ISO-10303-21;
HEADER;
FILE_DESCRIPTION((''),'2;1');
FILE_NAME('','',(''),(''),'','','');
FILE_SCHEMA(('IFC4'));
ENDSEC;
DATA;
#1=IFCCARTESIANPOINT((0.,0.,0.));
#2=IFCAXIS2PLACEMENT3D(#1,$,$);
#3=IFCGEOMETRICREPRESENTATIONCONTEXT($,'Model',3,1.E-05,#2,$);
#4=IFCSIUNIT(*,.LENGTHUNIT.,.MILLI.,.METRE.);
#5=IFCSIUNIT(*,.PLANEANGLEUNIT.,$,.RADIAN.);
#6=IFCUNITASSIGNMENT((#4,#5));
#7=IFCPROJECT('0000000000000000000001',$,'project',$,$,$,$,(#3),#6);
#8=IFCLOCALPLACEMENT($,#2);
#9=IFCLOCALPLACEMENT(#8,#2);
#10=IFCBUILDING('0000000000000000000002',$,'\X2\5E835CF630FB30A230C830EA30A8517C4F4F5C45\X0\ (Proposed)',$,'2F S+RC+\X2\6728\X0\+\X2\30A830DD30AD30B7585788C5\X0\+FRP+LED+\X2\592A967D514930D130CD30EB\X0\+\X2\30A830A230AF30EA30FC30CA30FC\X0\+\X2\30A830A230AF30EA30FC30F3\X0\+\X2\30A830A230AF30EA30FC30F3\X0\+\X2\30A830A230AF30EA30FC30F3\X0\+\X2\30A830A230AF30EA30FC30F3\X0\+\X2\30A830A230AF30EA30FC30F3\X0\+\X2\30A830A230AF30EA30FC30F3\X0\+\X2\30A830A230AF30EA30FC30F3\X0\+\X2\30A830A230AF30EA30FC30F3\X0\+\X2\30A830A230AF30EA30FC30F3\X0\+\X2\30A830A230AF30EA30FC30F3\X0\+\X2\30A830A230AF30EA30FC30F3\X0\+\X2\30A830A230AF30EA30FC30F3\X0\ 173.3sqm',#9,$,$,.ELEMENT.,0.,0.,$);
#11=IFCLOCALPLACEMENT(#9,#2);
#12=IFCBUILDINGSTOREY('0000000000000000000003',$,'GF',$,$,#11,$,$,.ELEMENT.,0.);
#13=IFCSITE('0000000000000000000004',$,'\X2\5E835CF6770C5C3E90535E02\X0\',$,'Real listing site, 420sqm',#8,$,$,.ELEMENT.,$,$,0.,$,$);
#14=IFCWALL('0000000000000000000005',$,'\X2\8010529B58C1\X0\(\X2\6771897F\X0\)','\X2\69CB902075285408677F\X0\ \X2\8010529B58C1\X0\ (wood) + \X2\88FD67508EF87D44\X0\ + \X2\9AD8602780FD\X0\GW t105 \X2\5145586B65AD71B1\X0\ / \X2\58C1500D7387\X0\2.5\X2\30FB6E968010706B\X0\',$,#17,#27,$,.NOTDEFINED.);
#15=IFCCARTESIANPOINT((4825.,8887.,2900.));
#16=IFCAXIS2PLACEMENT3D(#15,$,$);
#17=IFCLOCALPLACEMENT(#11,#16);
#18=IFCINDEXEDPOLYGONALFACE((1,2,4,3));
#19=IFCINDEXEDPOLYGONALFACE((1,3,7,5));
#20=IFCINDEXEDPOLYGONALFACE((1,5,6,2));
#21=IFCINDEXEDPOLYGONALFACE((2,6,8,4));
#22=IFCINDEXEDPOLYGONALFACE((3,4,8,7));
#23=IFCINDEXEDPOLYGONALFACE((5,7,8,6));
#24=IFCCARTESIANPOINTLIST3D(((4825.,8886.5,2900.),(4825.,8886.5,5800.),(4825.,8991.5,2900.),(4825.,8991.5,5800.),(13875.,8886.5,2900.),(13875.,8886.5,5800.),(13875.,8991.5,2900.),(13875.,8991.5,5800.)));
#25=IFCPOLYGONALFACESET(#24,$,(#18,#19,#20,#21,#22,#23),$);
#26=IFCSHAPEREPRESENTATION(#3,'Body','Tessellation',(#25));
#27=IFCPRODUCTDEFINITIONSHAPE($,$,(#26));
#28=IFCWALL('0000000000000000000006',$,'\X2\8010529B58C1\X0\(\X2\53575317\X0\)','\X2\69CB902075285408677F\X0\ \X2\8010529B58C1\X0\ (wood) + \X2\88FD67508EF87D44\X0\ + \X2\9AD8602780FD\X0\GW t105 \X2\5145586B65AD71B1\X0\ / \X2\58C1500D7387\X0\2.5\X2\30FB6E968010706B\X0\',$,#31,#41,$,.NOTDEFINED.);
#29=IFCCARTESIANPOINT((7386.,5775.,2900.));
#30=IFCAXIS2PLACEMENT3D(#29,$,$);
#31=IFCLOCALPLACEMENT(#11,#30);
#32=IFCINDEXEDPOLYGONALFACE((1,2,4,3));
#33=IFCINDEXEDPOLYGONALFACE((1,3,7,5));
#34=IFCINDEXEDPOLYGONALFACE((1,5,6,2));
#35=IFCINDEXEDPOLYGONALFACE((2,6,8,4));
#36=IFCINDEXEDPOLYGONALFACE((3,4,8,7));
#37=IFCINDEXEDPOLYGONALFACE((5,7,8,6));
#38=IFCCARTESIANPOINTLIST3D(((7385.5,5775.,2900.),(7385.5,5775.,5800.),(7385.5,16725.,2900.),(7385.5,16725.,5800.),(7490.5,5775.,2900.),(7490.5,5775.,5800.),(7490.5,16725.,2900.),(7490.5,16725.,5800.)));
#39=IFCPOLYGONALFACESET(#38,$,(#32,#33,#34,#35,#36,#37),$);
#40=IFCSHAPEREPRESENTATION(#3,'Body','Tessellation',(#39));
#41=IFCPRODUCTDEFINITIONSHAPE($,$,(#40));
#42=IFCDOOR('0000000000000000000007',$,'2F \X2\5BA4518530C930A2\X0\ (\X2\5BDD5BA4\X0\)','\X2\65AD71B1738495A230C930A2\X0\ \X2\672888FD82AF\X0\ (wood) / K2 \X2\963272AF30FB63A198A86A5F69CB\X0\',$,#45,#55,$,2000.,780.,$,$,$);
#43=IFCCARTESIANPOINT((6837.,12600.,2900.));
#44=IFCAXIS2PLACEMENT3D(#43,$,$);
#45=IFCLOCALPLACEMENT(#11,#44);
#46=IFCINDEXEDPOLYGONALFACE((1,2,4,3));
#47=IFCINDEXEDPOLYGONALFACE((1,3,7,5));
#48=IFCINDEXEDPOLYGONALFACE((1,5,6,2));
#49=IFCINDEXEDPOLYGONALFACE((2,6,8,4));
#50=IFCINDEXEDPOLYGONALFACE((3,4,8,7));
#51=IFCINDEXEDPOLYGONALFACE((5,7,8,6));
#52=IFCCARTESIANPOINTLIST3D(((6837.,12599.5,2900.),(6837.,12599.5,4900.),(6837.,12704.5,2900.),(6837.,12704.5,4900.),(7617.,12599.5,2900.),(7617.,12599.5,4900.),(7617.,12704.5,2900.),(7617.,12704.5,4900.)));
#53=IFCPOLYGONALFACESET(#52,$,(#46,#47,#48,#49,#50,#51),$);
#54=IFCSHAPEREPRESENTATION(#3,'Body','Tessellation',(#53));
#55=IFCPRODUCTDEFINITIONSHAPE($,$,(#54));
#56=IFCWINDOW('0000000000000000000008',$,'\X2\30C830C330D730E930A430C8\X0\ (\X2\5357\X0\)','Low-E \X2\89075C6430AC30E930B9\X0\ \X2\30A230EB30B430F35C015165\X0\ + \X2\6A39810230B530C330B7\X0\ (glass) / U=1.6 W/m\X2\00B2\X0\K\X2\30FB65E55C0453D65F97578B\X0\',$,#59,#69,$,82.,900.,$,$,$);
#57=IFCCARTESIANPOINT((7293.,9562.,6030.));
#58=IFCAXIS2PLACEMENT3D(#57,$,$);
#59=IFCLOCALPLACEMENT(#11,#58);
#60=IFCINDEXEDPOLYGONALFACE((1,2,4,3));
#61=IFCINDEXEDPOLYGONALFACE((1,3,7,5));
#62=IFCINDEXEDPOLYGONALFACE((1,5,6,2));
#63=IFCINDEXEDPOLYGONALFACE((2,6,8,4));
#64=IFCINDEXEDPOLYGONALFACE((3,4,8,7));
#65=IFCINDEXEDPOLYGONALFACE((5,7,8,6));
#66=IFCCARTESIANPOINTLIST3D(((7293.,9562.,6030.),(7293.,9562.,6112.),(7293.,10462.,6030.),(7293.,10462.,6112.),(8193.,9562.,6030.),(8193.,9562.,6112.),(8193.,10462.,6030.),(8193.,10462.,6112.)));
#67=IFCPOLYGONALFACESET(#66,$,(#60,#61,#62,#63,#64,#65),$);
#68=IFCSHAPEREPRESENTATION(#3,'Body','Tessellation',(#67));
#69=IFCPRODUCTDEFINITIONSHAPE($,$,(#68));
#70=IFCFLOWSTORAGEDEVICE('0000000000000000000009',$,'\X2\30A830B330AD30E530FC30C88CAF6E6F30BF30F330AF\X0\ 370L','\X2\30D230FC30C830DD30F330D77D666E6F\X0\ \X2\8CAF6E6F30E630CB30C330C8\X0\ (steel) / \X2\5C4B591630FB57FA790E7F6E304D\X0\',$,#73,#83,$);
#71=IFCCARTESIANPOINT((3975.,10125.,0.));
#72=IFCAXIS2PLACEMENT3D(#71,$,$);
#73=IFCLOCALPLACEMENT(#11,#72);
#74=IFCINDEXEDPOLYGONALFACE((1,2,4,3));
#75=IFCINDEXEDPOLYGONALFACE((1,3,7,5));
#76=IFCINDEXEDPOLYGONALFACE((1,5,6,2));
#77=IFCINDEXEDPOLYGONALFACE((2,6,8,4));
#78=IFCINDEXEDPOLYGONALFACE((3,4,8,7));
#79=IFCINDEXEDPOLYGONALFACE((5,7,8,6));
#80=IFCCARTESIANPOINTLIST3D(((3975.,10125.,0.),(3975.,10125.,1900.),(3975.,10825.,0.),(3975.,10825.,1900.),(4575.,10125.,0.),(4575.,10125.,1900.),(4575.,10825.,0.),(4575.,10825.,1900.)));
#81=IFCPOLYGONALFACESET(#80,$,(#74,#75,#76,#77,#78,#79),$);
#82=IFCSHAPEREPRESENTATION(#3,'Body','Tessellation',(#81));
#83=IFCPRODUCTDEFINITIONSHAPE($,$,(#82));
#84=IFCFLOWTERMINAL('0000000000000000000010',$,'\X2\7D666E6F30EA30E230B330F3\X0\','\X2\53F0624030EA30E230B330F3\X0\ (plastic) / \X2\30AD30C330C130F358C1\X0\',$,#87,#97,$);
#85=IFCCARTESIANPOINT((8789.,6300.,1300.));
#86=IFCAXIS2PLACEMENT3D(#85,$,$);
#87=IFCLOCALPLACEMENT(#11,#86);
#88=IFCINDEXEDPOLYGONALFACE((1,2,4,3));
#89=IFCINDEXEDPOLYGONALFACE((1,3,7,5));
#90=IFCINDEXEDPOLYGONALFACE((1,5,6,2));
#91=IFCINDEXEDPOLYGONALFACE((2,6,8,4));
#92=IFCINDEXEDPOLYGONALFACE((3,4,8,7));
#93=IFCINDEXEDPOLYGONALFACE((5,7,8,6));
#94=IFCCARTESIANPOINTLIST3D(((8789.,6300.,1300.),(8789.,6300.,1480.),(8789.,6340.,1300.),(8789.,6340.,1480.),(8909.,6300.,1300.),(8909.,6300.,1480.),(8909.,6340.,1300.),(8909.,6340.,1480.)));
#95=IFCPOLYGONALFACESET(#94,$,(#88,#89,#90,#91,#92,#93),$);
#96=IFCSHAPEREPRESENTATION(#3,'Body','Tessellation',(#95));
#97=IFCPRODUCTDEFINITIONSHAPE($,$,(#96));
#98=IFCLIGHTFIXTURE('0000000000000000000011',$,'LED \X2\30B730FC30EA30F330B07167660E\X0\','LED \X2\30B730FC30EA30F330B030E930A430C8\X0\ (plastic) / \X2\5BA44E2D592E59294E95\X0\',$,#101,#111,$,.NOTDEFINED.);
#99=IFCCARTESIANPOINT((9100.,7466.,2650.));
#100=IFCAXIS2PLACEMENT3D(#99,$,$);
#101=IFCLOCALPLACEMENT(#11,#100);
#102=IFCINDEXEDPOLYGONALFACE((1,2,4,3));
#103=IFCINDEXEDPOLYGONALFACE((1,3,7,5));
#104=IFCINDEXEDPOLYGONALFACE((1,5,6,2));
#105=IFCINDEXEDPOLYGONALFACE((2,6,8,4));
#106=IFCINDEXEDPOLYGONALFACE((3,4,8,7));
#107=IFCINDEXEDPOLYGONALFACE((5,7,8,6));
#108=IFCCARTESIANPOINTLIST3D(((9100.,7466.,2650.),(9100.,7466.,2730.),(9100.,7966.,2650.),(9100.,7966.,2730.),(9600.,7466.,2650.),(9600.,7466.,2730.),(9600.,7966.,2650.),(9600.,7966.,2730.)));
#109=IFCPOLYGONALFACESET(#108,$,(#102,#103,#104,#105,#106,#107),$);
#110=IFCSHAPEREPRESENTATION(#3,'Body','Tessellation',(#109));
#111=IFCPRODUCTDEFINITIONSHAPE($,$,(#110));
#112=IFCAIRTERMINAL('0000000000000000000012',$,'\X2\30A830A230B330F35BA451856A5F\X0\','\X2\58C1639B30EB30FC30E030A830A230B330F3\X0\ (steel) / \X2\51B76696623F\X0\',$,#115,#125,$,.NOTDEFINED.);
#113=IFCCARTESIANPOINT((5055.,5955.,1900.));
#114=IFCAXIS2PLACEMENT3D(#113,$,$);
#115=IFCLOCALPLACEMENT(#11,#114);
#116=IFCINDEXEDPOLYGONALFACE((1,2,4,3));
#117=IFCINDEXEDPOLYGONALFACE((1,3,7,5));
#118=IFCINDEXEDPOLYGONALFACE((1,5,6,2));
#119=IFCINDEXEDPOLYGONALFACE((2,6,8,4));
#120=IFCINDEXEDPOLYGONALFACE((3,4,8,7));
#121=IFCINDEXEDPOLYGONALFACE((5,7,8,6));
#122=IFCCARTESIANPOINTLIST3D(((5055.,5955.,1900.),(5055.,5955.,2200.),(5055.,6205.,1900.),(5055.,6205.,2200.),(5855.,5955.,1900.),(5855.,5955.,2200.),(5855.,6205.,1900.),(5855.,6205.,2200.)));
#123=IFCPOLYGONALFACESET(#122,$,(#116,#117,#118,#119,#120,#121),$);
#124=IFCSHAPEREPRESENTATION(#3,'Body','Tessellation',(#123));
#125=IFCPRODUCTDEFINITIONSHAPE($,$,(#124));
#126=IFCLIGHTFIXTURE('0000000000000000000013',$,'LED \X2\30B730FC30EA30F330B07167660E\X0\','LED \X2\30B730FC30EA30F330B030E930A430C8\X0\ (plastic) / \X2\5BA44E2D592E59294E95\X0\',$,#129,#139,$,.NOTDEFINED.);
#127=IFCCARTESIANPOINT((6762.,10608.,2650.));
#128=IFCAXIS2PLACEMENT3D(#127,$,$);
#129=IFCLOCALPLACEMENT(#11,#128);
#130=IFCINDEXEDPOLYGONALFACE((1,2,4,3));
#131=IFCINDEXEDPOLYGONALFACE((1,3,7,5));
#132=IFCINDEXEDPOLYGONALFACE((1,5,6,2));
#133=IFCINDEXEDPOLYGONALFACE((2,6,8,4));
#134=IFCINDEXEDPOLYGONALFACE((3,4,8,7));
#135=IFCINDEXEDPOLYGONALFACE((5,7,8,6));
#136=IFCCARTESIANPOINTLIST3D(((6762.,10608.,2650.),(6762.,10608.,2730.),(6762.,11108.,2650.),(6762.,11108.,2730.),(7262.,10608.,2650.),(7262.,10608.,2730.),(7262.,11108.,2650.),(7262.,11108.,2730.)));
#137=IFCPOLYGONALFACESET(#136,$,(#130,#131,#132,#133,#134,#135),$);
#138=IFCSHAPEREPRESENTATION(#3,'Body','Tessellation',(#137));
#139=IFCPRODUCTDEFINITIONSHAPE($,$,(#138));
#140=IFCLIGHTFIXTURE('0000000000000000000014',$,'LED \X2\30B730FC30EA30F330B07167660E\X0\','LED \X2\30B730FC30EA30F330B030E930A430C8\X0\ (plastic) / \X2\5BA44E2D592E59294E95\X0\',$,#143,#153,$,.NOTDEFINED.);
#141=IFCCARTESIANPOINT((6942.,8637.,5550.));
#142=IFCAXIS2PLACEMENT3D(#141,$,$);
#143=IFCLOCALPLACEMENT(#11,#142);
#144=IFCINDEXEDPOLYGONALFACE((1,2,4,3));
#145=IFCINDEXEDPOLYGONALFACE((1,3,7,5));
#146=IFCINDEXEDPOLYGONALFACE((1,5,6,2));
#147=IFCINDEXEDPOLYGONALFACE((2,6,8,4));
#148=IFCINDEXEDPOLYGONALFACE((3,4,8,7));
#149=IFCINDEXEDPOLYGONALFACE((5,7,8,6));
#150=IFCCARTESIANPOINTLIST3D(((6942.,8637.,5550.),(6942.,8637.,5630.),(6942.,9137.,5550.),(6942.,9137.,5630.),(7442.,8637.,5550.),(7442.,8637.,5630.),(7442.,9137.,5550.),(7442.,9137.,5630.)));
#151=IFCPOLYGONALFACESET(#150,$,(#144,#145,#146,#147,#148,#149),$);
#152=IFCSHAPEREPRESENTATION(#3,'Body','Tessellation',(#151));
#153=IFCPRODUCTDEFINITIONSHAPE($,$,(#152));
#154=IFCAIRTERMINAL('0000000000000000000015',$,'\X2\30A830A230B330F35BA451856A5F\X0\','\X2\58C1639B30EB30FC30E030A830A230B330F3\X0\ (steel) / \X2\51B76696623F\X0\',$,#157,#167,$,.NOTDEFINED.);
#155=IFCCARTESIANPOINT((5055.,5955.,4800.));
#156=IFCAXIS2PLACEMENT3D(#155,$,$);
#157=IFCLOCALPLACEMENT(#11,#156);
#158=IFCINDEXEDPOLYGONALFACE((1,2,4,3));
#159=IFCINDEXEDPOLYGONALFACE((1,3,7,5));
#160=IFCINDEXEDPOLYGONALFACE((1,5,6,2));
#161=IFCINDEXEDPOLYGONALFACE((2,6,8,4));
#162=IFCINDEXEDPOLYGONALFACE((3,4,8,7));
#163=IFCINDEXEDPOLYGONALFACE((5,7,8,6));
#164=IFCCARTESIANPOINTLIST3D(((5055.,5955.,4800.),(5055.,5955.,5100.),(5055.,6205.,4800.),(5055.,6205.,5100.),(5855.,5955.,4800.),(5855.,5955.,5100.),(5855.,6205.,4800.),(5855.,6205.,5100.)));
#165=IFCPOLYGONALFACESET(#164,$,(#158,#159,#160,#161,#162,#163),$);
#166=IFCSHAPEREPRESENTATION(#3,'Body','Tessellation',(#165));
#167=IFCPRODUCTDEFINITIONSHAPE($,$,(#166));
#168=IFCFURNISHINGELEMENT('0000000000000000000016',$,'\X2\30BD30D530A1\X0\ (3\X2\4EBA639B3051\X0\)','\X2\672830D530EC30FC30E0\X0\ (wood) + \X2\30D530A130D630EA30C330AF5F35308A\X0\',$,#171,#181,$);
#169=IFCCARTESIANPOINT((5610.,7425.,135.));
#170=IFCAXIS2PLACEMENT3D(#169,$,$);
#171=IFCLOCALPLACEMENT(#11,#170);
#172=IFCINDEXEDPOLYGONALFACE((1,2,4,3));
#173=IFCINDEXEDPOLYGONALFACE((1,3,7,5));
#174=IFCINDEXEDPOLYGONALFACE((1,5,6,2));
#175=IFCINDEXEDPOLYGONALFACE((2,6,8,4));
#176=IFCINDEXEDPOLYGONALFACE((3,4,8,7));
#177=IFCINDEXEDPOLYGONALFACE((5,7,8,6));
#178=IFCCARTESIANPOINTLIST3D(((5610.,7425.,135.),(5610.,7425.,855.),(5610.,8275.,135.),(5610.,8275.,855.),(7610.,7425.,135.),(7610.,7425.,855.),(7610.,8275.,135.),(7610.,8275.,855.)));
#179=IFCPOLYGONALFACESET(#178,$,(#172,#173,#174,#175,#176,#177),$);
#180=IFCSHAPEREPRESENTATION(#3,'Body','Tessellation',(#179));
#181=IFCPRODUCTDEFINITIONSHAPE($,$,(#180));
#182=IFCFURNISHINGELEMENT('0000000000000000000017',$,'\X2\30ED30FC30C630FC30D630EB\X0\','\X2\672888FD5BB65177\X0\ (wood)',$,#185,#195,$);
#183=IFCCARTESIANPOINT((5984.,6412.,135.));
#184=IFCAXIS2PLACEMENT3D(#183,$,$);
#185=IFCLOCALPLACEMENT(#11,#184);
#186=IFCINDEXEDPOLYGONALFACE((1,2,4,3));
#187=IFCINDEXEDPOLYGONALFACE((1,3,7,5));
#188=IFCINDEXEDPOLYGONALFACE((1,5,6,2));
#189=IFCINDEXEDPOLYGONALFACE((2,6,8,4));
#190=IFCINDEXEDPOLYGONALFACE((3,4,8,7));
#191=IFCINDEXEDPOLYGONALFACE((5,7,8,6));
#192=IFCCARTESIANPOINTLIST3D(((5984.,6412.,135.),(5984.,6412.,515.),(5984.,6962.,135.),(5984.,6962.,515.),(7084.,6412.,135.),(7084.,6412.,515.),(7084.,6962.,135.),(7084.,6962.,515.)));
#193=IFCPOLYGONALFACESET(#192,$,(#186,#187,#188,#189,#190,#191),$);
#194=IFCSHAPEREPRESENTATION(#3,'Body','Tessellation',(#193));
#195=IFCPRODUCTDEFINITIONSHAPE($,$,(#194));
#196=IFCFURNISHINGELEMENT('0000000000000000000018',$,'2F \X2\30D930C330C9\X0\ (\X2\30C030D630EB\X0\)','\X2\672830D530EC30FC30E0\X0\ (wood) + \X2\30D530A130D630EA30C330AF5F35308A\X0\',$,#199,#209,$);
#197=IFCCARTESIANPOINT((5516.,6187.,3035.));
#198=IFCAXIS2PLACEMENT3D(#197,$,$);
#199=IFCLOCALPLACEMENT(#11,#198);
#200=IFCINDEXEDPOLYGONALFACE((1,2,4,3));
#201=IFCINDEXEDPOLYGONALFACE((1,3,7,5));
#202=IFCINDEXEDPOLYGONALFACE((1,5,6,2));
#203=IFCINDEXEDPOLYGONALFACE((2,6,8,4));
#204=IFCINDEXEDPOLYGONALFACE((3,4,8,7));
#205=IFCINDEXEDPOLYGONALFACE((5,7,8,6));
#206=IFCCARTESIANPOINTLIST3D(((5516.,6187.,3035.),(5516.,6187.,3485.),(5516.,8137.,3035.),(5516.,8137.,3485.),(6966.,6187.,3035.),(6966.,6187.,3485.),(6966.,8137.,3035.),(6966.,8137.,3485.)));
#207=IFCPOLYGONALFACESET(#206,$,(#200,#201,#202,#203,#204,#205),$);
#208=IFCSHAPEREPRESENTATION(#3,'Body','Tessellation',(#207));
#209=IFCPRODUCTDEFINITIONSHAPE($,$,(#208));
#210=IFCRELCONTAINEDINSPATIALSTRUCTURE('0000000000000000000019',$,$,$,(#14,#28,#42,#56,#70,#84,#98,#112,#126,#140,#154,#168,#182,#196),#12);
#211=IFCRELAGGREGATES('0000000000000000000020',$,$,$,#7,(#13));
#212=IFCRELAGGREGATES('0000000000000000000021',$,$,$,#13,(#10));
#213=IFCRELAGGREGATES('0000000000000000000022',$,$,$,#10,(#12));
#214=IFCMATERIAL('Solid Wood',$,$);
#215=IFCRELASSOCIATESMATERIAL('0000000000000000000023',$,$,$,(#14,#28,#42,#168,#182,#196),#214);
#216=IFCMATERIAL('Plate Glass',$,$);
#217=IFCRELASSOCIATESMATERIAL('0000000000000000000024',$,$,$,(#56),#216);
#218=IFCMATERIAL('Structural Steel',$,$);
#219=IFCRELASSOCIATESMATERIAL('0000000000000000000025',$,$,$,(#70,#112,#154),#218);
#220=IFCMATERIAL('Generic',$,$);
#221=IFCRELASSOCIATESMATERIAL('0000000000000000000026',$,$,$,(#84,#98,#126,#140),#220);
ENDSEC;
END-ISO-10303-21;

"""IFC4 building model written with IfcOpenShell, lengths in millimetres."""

from ifc_helpers import new_model, si_unit, frame, frame_2d, origin, place, context, project, spatial, rectangle, extrude, material, element, fill, save


model = new_model("IFC4")

# Units and contexts
model_context = context("Model", 3, precision=1e-05, world=origin())
ifc_project = project(units=[si_unit("LENGTHUNIT", "METRE", prefix="MILLI"), si_unit("PLANEANGLEUNIT", "RADIAN")], contexts=[model_context])

# Site, building, storey
site_placement = place(None, origin())
site = spatial("IfcSite", under=ifc_project, at=site_placement, Name="広島県尾道市", ObjectType="Real listing site, 420sqm", CompositionType="ELEMENT", RefElevation=0.0)
building_placement = place(site_placement, origin())
building = spatial("IfcBuilding", under=site, at=building_placement, Name="広島・アトリエ兼住居 (Proposed)", ObjectType="2F S+RC+木+エポキシ塗装+FRP+LED+太陽光パネル+エアクリーナー+エアクリーン+エアクリーン+エアクリーン+エアクリーン+エアクリーン+エアクリーン+エアクリーン+エアクリーン+エアクリーン+エアクリーン+エアクリーン+エアクリーン 173.3sqm", CompositionType="ELEMENT", ElevationOfRefHeight=0.0, ElevationOfTerrain=0.0)
storey_placement = place(building_placement, origin())
storey = spatial("IfcBuildingStorey", under=building, at=storey_placement, Name="GF", CompositionType="ELEMENT", Elevation=0.0)

# Shared definitions
ifc_material_1 = material(Name="Solid Wood")

# Wall
wall_1_placement = place(storey_placement, frame((4825.0, 8887.0, 2900.0)))
element("IfcWall", 1, at=wall_1_placement, inside=storey, material=ifc_material_1, Name="耐力壁(東西)", Description="構造用合板 耐力壁 (wood) + 製材軸組 + 高性能GW t105 充填断熱 / 壁倍率2.5・準耐火", PredefinedType="NOTDEFINED", context=model_context, shape_type="SweptSolid", body=[
    extrude(rectangle(XDim=9050.0, YDim=105.0, at=frame_2d((4525.0, 52.0))), frame((4825.0, 8887.0, 2900.0)), (0.0, 0.0, 1.0), 2900.0),
])

# Wall, opening, door
wall_2_placement = place(storey_placement, frame((7386.0, 5775.0, 2900.0)))
wall_2 = element("IfcWall", 2, at=wall_2_placement, inside=storey, material=ifc_material_1, Name="耐力壁(南北)", Description="構造用合板 耐力壁 (wood) + 製材軸組 + 高性能GW t105 充填断熱 / 壁倍率2.5・準耐火", PredefinedType="NOTDEFINED", context=model_context, shape_type="SweptSolid", body=[
    extrude(rectangle(XDim=105.0, YDim=10950.0, at=frame_2d((52.0, 5475.0))), frame((7386.0, 5775.0, 2900.0)), (0.0, 0.0, 1.0), 2900.0),
])
opening_placement = place(storey_placement, frame((6837.0, 12600.0, 2900.0)))
opening = element("IfcOpeningElement", 3, at=opening_placement, cuts=wall_2, PredefinedType="NOTDEFINED", context=model_context, shape_type="SweptSolid", body=[
    extrude(rectangle(XDim=780.0, YDim=105.0, at=frame_2d((390.0, 52.0))), frame((6837.0, 12600.0, 2900.0)), (0.0, 0.0, 1.0), 2000.0),
])
door_placement = place(storey_placement, frame((6837.0, 12600.0, 2900.0)))
door = element("IfcDoor", 4, at=door_placement, inside=storey, material=ifc_material_1, Name="2F 室内ドア (寝室)", Description="断熱玄関ドア 木製芯 (wood) / K2 防犯・採風機構", OverallHeight=2000.0, OverallWidth=780.0, context=model_context, shape_type="SweptSolid", body=[
    extrude(rectangle(XDim=780.0, YDim=105.0, at=frame_2d((390.0, 52.0))), frame((6837.0, 12600.0, 2900.0)), (0.0, 0.0, 1.0), 2000.0),
])
fill(opening, door)

# Window
ifc_material_2 = material(Name="Plate Glass")
window_placement = place(storey_placement, frame((7293.0, 9562.0, 6030.0)))
element("IfcWindow", 5, at=window_placement, inside=storey, material=ifc_material_2, Name="トップライト (南)", Description="Low-E 複層ガラス アルゴン封入 + 樹脂サッシ (glass) / U=1.6 W/m²K・日射取得型", OverallHeight=82.0, OverallWidth=900.0, context=model_context, shape_type="SweptSolid", body=[
    extrude(rectangle(XDim=900.0, YDim=900.0, at=frame_2d((450.0, 450.0))), frame((7293.0, 9562.0, 6030.0)), (0.0, 0.0, 1.0), 82.0),
])

# Flow storage device
ifc_material_3 = material(Name="Structural Steel")
flow_storage_device_placement = place(storey_placement, frame((3975.0, 10125.0, 0.0)))
element("IfcFlowStorageDevice", 6, at=flow_storage_device_placement, inside=storey, material=ifc_material_3, Name="エコキュート貯湯タンク 370L", Description="ヒートポンプ給湯 貯湯ユニット (steel) / 屋外・基礎置き", context=model_context, shape_type="SweptSolid", body=[
    extrude(rectangle(XDim=600.0, YDim=700.0, at=frame_2d((300.0, 350.0))), frame((3975.0, 10125.0, 0.0)), (0.0, 0.0, 1.0), 1900.0),
])

# Flow terminal
ifc_material_4 = material(Name="Generic")
flow_terminal_placement = place(storey_placement, frame((8789.0, 6300.0, 1300.0)))
element("IfcFlowTerminal", 7, at=flow_terminal_placement, inside=storey, material=ifc_material_4, Name="給湯リモコン", Description="台所リモコン (plastic) / キッチン壁", context=model_context, shape_type="SweptSolid", body=[
    extrude(rectangle(XDim=120.0, YDim=40.0, at=frame_2d((60.0, 20.0))), frame((8789.0, 6300.0, 1300.0)), (0.0, 0.0, 1.0), 180.0),
])

# Light fixture
light_fixture_1_placement = place(storey_placement, frame((9100.0, 7466.0, 2650.0)))
element("IfcLightFixture", 8, at=light_fixture_1_placement, inside=storey, material=ifc_material_4, Name="LED シーリング照明", Description="LED シーリングライト (plastic) / 室中央天井", PredefinedType="NOTDEFINED", context=model_context, shape_type="SweptSolid", body=[
    extrude(rectangle(XDim=500.0, YDim=500.0, at=frame_2d((250.0, 250.0))), frame((9100.0, 7466.0, 2650.0)), (0.0, 0.0, 1.0), 80.0),
])

# Air terminal
air_terminal_1_placement = place(storey_placement, frame((5055.0, 5955.0, 1900.0)))
element("IfcAirTerminal", 9, at=air_terminal_1_placement, inside=storey, material=ifc_material_3, Name="エアコン室内機", Description="壁掛ルームエアコン (steel) / 冷暖房", PredefinedType="NOTDEFINED", context=model_context, shape_type="SweptSolid", body=[
    extrude(rectangle(XDim=800.0, YDim=250.0, at=frame_2d((400.0, 125.0))), frame((5055.0, 5955.0, 1900.0)), (0.0, 0.0, 1.0), 300.0),
])

# Light fixtures
light_fixture_2_placement = place(storey_placement, frame((6762.0, 10608.0, 2650.0)))
element("IfcLightFixture", 10, at=light_fixture_2_placement, inside=storey, material=ifc_material_4, Name="LED シーリング照明", Description="LED シーリングライト (plastic) / 室中央天井", PredefinedType="NOTDEFINED", context=model_context, shape_type="SweptSolid", body=[
    extrude(rectangle(XDim=500.0, YDim=500.0, at=frame_2d((250.0, 250.0))), frame((6762.0, 10608.0, 2650.0)), (0.0, 0.0, 1.0), 80.0),
])
light_fixture_3_placement = place(storey_placement, frame((6942.0, 8637.0, 5550.0)))
element("IfcLightFixture", 11, at=light_fixture_3_placement, inside=storey, material=ifc_material_4, Name="LED シーリング照明", Description="LED シーリングライト (plastic) / 室中央天井", PredefinedType="NOTDEFINED", context=model_context, shape_type="SweptSolid", body=[
    extrude(rectangle(XDim=500.0, YDim=500.0, at=frame_2d((250.0, 250.0))), frame((6942.0, 8637.0, 5550.0)), (0.0, 0.0, 1.0), 80.0),
])

# Air terminal
air_terminal_2_placement = place(storey_placement, frame((5055.0, 5955.0, 4800.0)))
element("IfcAirTerminal", 12, at=air_terminal_2_placement, inside=storey, material=ifc_material_3, Name="エアコン室内機", Description="壁掛ルームエアコン (steel) / 冷暖房", PredefinedType="NOTDEFINED", context=model_context, shape_type="SweptSolid", body=[
    extrude(rectangle(XDim=800.0, YDim=250.0, at=frame_2d((400.0, 125.0))), frame((5055.0, 5955.0, 4800.0)), (0.0, 0.0, 1.0), 300.0),
])

# Furnishing elements
furnishing_1_placement = place(storey_placement, frame((5610.0, 7425.0, 135.0)))
element("IfcFurnishingElement", 13, at=furnishing_1_placement, inside=storey, material=ifc_material_1, Name="ソファ (3人掛け)", Description="木フレーム (wood) + ファブリック張り", context=model_context, shape_type="SweptSolid", body=[
    extrude(rectangle(XDim=2000.0, YDim=850.0, at=frame_2d((1000.0, 425.0))), frame((5610.0, 7425.0, 135.0)), (0.0, 0.0, 1.0), 720.0),
])
furnishing_2_placement = place(storey_placement, frame((5984.0, 6412.0, 135.0)))
element("IfcFurnishingElement", 14, at=furnishing_2_placement, inside=storey, material=ifc_material_1, Name="ローテーブル", Description="木製家具 (wood)", context=model_context, shape_type="SweptSolid", body=[
    extrude(rectangle(XDim=1100.0, YDim=550.0, at=frame_2d((550.0, 275.0))), frame((5984.0, 6412.0, 135.0)), (0.0, 0.0, 1.0), 380.0),
])
furnishing_3_placement = place(storey_placement, frame((5516.0, 6187.0, 3035.0)))
element("IfcFurnishingElement", 15, at=furnishing_3_placement, inside=storey, material=ifc_material_1, Name="2F ベッド (ダブル)", Description="木フレーム (wood) + ファブリック張り", context=model_context, shape_type="SweptSolid", body=[
    extrude(rectangle(XDim=1450.0, YDim=1950.0, at=frame_2d((725.0, 975.0))), frame((5516.0, 6187.0, 3035.0)), (0.0, 0.0, 1.0), 450.0),
])

save(model, "model.ifc")
